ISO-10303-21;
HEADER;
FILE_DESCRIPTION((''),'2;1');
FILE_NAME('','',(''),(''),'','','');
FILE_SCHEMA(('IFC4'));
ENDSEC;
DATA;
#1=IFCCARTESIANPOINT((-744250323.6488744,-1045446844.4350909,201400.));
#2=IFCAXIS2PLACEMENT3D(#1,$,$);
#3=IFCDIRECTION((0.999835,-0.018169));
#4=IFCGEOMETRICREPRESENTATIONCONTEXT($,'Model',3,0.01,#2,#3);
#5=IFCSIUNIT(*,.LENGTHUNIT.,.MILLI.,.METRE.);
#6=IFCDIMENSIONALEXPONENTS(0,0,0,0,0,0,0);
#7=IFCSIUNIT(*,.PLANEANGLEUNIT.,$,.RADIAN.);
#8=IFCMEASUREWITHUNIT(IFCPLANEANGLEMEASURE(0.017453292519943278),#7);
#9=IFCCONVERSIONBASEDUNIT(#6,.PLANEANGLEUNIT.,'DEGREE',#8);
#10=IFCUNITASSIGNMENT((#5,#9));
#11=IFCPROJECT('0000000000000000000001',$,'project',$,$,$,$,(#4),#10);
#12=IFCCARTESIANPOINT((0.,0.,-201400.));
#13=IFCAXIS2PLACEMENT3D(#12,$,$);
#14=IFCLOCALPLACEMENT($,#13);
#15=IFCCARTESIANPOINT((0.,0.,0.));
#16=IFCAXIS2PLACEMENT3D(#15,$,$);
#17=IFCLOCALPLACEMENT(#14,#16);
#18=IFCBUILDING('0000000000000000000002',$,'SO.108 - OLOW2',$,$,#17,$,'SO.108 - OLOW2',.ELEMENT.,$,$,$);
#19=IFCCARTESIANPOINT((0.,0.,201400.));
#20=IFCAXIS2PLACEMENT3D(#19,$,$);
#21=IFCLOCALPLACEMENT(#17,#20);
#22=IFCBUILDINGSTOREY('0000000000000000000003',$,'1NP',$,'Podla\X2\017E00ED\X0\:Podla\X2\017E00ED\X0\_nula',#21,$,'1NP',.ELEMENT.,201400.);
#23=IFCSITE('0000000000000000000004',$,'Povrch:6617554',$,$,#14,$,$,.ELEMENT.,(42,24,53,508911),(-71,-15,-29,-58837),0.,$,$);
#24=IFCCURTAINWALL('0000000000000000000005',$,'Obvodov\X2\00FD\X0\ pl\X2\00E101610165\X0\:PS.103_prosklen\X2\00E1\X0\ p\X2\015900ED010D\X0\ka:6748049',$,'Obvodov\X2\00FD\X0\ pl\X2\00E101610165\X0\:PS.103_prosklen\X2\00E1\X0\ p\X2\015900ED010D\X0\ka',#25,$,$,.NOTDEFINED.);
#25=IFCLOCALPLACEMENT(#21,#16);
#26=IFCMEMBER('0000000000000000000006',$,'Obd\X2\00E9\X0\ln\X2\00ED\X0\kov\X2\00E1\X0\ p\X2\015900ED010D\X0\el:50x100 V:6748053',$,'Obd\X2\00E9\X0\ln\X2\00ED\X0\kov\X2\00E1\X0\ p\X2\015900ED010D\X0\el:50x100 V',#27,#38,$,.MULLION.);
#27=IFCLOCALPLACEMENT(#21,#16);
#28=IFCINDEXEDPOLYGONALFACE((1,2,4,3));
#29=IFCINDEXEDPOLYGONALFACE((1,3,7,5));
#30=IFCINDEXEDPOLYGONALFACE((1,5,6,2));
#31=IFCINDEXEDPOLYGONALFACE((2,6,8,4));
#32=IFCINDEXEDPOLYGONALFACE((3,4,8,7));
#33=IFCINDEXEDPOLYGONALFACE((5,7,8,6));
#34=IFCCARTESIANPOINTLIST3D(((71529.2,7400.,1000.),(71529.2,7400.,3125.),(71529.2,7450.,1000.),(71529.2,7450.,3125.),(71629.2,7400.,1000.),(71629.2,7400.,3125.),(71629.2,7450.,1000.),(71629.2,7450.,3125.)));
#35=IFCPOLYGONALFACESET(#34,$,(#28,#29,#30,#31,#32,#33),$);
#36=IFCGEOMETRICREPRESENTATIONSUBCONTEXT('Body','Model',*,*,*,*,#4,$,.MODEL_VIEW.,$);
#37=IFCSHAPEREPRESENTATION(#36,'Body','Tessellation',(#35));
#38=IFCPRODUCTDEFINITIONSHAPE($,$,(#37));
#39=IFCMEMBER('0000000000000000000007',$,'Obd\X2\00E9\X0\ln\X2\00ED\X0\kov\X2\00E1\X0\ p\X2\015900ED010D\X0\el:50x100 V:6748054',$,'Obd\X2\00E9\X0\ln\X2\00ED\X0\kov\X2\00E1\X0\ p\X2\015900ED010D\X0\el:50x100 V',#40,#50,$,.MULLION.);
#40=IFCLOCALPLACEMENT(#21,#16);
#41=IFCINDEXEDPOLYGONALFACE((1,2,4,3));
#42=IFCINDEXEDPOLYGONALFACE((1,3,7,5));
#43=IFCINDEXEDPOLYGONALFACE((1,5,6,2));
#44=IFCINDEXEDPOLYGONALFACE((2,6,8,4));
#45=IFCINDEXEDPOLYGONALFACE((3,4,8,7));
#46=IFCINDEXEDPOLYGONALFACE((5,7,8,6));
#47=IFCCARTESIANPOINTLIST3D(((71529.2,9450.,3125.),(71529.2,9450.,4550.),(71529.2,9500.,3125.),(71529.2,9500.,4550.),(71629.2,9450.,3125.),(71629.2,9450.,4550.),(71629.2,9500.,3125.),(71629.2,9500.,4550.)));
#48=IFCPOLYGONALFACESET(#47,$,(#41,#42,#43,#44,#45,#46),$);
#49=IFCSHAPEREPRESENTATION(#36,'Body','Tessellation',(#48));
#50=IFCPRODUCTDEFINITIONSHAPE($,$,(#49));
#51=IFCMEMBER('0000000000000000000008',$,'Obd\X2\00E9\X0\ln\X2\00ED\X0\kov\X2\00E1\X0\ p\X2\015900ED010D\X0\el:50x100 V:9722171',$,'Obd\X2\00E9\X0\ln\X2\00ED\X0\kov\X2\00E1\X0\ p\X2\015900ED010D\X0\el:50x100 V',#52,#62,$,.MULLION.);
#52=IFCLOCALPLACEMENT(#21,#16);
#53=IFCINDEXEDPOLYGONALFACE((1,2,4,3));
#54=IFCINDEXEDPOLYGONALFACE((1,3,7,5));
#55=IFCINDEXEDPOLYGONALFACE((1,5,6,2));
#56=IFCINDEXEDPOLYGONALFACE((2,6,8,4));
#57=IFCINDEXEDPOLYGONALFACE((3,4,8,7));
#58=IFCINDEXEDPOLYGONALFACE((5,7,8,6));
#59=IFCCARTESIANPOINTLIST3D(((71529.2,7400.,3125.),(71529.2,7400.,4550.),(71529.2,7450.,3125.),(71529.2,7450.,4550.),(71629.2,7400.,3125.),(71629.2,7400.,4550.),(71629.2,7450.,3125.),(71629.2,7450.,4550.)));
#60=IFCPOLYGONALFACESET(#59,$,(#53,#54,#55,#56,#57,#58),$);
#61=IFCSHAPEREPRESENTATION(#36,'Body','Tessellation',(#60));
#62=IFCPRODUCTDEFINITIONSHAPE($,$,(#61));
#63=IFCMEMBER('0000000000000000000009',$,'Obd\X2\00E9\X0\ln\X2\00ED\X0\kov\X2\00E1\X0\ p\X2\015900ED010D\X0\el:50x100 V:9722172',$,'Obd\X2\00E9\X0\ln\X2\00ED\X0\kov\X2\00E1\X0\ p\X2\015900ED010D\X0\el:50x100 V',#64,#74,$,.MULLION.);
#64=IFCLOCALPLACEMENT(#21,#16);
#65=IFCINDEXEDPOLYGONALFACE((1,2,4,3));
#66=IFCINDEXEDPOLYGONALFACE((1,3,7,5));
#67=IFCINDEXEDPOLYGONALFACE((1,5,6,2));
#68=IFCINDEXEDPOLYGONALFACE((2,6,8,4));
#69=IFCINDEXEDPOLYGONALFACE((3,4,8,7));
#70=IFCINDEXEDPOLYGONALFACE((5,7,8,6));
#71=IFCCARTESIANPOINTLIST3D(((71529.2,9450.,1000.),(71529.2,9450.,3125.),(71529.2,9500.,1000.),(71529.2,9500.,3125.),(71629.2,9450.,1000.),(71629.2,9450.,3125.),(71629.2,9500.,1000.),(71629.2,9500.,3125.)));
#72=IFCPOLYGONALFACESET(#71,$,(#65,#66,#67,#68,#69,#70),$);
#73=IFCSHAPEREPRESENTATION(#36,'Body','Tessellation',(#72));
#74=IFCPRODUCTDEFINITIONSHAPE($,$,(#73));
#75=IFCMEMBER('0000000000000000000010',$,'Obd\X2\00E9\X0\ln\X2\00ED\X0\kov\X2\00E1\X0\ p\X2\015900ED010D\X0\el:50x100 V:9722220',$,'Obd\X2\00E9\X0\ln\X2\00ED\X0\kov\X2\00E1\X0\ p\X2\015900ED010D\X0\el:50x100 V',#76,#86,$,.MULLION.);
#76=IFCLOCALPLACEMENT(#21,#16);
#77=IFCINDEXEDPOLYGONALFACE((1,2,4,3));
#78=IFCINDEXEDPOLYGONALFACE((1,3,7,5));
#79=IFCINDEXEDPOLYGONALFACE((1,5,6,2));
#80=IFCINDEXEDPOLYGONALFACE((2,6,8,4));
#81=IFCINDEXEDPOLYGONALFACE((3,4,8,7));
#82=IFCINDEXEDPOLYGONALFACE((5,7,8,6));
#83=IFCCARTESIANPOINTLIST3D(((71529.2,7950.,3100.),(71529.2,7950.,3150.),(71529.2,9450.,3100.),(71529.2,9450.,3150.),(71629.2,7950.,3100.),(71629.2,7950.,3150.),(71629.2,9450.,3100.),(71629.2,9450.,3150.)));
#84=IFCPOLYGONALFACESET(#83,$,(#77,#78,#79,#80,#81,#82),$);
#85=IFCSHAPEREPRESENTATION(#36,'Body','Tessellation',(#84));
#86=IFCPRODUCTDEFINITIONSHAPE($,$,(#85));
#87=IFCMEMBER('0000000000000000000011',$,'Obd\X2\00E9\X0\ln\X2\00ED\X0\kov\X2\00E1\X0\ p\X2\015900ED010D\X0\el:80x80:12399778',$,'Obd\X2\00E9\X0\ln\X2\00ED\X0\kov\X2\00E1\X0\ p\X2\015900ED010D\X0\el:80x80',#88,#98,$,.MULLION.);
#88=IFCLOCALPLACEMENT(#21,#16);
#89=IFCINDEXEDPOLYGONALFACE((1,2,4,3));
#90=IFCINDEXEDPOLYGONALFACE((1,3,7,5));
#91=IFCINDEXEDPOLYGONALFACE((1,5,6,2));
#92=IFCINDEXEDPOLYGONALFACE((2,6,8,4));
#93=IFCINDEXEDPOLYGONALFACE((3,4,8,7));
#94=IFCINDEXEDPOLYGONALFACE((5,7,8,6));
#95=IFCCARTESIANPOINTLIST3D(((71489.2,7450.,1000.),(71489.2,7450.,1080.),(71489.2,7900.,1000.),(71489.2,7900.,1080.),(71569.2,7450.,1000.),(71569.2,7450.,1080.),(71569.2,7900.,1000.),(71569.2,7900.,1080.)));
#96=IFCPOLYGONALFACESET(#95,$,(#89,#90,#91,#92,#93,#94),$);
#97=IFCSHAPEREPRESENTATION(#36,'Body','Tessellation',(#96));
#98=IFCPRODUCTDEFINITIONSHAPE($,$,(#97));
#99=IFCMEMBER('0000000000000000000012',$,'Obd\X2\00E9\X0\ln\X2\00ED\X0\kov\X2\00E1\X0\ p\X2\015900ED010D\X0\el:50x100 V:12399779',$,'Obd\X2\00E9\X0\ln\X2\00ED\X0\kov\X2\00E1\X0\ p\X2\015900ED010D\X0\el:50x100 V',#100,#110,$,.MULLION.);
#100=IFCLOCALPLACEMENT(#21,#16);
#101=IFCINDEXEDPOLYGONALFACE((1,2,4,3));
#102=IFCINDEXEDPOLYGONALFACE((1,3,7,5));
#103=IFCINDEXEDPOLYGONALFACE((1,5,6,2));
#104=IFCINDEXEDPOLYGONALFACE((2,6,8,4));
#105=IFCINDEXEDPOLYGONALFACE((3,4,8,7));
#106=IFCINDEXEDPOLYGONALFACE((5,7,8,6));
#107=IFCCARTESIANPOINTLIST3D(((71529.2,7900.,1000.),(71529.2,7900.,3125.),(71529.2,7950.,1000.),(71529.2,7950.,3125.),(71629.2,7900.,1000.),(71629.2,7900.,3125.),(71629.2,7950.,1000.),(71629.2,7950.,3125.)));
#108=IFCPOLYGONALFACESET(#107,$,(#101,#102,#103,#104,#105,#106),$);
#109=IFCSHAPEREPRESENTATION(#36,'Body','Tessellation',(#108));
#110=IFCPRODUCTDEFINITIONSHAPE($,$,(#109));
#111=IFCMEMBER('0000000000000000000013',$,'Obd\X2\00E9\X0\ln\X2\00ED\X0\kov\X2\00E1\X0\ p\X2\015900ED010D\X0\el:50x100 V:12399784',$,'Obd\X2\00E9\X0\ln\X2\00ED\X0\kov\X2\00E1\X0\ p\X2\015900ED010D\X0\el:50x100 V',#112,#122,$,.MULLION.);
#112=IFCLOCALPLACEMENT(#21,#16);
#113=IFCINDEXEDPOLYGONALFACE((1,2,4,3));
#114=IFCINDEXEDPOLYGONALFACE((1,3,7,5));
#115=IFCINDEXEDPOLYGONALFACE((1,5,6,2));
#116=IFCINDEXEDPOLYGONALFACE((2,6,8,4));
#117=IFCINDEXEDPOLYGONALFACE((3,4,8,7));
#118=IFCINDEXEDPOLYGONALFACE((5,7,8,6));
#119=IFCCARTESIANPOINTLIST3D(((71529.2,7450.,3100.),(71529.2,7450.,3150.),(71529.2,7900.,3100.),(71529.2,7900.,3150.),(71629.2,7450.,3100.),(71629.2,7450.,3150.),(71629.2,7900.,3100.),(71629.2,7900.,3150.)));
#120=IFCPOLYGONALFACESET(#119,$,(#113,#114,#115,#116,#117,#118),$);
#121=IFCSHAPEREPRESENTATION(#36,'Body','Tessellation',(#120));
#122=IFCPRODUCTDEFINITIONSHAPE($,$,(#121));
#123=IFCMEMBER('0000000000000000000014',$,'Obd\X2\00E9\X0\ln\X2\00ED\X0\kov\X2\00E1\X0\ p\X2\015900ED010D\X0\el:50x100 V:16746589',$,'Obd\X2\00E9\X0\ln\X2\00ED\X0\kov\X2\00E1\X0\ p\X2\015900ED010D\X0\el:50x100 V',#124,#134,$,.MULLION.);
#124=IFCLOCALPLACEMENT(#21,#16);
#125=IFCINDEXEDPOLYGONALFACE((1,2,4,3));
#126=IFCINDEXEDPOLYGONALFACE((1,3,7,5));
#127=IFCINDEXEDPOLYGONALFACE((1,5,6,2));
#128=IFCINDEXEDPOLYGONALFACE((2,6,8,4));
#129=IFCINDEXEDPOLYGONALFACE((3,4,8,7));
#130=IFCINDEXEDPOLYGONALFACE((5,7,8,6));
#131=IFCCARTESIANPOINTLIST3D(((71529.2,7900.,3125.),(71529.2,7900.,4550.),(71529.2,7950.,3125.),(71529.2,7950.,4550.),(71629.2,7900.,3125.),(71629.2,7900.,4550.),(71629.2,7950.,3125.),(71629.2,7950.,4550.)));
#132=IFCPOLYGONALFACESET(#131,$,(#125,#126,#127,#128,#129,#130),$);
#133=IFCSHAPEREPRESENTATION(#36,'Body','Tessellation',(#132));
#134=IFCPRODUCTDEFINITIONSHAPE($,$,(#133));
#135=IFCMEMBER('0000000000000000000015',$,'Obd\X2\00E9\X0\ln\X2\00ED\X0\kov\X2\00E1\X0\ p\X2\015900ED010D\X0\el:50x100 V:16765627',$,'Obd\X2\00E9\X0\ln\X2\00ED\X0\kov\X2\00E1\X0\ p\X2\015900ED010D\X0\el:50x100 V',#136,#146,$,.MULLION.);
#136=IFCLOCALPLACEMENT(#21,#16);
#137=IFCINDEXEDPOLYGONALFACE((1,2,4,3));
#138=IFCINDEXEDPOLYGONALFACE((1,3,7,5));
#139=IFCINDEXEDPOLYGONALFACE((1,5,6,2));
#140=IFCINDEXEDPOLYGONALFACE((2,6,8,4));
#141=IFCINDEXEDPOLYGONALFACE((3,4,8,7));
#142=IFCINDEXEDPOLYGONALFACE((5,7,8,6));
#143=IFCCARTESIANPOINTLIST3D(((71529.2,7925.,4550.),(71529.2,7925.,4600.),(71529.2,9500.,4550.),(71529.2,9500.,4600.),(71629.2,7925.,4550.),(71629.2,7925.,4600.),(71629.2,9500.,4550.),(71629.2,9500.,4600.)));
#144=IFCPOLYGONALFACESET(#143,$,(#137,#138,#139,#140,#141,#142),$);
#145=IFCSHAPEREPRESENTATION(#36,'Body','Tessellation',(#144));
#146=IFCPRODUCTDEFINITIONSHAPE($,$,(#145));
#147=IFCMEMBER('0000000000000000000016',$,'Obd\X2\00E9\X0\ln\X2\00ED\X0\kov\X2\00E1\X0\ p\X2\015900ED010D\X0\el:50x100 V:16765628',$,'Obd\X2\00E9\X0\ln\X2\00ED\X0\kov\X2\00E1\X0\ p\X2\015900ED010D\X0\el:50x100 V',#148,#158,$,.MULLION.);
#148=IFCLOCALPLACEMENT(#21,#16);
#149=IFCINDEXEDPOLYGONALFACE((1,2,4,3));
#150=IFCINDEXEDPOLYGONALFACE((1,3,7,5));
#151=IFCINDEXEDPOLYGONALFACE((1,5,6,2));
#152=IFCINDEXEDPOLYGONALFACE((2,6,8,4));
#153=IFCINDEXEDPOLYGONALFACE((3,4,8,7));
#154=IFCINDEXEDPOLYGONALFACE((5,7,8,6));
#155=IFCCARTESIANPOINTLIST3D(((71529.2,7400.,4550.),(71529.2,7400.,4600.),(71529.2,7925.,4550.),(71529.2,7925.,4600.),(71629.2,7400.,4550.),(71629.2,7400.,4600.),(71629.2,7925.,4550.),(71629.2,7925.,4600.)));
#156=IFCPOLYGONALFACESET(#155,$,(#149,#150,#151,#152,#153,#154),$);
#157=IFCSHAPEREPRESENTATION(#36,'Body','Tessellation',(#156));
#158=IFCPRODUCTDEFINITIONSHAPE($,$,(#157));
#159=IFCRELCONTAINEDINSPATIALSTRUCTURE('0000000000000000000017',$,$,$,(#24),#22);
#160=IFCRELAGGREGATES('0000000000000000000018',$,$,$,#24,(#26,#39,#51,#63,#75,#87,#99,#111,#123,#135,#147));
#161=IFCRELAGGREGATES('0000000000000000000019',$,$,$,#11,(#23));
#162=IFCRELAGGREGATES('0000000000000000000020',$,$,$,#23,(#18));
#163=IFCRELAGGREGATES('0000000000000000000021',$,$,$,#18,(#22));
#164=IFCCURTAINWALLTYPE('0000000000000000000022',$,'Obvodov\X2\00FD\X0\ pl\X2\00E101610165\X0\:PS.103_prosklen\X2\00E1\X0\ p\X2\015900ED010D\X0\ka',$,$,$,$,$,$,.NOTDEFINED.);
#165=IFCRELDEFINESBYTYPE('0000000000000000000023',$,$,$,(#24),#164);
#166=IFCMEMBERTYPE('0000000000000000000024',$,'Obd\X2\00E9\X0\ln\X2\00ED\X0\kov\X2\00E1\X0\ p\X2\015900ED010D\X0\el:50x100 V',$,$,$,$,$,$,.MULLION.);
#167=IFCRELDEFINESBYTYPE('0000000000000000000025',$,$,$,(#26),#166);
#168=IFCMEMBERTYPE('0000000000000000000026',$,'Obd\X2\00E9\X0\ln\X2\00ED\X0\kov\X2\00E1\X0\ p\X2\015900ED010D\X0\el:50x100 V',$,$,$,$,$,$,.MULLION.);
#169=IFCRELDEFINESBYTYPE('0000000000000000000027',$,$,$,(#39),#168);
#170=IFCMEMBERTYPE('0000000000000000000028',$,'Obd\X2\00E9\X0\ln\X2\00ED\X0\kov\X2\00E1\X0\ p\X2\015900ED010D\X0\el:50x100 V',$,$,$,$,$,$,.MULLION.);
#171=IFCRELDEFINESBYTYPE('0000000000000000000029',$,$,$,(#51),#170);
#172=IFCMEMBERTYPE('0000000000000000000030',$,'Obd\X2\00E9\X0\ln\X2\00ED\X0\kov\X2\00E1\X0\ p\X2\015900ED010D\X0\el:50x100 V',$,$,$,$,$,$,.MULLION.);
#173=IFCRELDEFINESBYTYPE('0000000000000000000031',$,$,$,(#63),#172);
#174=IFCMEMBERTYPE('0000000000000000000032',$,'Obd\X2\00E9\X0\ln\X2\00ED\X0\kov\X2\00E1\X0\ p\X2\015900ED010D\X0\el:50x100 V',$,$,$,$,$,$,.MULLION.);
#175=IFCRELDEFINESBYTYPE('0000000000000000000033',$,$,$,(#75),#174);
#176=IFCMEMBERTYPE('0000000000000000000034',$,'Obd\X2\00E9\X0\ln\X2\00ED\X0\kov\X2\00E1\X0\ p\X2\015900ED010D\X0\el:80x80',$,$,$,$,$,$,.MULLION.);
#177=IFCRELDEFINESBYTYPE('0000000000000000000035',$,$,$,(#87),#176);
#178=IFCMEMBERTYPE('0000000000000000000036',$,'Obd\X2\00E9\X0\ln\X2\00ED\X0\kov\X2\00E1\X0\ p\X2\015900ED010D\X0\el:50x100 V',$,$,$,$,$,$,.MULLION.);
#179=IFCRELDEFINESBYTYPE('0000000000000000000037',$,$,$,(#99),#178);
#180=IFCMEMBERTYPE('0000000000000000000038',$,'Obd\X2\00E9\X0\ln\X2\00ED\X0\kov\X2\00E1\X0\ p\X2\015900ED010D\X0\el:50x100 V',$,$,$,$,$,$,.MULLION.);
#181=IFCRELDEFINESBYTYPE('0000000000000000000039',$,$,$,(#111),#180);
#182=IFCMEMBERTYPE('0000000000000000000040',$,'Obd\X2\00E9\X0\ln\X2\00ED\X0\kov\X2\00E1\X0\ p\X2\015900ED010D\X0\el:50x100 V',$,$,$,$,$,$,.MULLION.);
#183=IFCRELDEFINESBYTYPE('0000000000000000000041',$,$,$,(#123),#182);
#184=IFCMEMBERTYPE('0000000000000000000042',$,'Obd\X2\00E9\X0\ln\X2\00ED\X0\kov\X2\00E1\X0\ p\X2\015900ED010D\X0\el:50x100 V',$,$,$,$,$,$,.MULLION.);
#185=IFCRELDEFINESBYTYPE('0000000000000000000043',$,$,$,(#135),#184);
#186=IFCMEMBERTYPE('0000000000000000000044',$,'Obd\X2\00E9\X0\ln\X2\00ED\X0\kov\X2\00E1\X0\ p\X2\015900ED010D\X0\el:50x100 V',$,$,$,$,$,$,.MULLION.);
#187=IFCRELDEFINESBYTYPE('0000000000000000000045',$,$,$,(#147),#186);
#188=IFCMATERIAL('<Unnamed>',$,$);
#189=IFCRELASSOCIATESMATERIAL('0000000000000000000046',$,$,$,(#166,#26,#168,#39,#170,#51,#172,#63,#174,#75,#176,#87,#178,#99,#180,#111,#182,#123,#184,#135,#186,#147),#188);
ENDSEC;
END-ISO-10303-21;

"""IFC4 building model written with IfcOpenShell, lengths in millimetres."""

from ifc_helpers import new_model, entity, si_unit, converted_unit, direction, frame, origin, place, context, subcontext, project, spatial, indexed_curve, outline, extrude, source, transform, mapped, material, type_object, type_shapes, element, aggregate, save


model = new_model("IFC4")

# Units and contexts
model_context = context("Model", 3, precision=0.01, world=frame((-744250323.6488744, -1045446844.4350909, 201400.0)), true_north=direction((0.999835, -0.018169)))
body_context = subcontext(model_context, "Body", "Model", "MODEL_VIEW")
ifc_project = project(units=[si_unit("LENGTHUNIT", "METRE", prefix="MILLI"), converted_unit("PLANEANGLEUNIT", "DEGREE", entity("IfcPlaneAngleMeasure", 0.017453292519943278), si_unit("PLANEANGLEUNIT", "RADIAN"), dimensions=[0, 0, 0, 0, 0, 0, 0])], contexts=[model_context])

# Site, building, storey
site_placement = place(None, frame((0.0, 0.0, -201400.0)))
site = spatial("IfcSite", under=ifc_project, at=site_placement, Name="Povrch:6617554", CompositionType="ELEMENT", RefLatitude=(42, 24, 53, 508911), RefLongitude=(-71, -15, -29, -58837), RefElevation=0.0)
building_placement = place(site_placement, origin())
building = spatial("IfcBuilding", under=site, at=building_placement, Name="SO.108 - OLOW2", LongName="SO.108 - OLOW2", CompositionType="ELEMENT")
storey_placement = place(building_placement, frame((0.0, 0.0, 201400.0)))
storey = spatial("IfcBuildingStorey", under=building, at=storey_placement, Name="1NP", ObjectType="Podlaží:Podlaží_nula", LongName="1NP", CompositionType="ELEMENT", Elevation=201400.0)

# Curtain wall, members
curtain_wall_type_1 = type_object("IfcCurtainWallType", Name="Obvodový plášť:PS.103_prosklená příčka", PredefinedType="NOTDEFINED")
curtain_wall_1_placement = place(storey_placement, frame((0.0, 0.0, -201400.0)))
curtain_wall_1 = element("IfcCurtainWall", 1, at=curtain_wall_1_placement, inside=storey, type_object=curtain_wall_type_1, Name="Obvodový plášť:PS.103_prosklená příčka:6748049", ObjectType="Obvodový plášť:PS.103_prosklená příčka", PredefinedType="NOTDEFINED")
ifc_material_1 = material(Name="<Unnamed>")
member_type_1 = type_object("IfcMemberType", Name="Obdélníková příčel:50x100 V", PredefinedType="MULLION", material=ifc_material_1)
shared_shape_1 = source(origin(), body_context, "Body", "SweptSolid", [
    extrude(outline(indexed_curve([(-25.0, -50.0), (25.0, -50.0), (25.0, 50.0), (-25.0, 50.0), (-25.0, -50.0)], self_intersect=False)), frame((-25.0, -50.0, -2125.0), z_axis=(0.0, 0.0, 1.0), x_axis=(-1.0, 0.0, 0.0)), (0.0, 0.0, 1.0), 2125.0),
])
type_shapes(member_type_1, [shared_shape_1])
member_1_placement = place(curtain_wall_1_placement, frame((71529.2, 7400.0, 202400.0), z_axis=(0.0, 0.0, -1.0), x_axis=(0.0, -1.0, 0.0)))
member_1 = element("IfcMember", 2, at=member_1_placement, type_object=member_type_1, material=ifc_material_1, Name="Obdélníková příčel:50x100 V:6748053", ObjectType="Obdélníková příčel:50x100 V", PredefinedType="MULLION", context=body_context, shape_type="MappedRepresentation", body=[
    mapped(shared_shape_1, transform((0.0, 0.0, 0.0), scale=1.0)),
])
member_type_2 = type_object("IfcMemberType", Name="Obdélníková příčel:50x100 V", PredefinedType="MULLION", material=ifc_material_1)
shared_shape_2 = source(origin(), body_context, "Body", "SweptSolid", [
    extrude(outline(indexed_curve([(-25.0, -50.0), (25.0, -50.0), (25.0, 50.0), (-25.0, 50.0), (-25.0, -50.0)], self_intersect=False)), frame((-25.0, -50.0, -1425.0), z_axis=(0.0, 0.0, 1.0), x_axis=(-1.0, 0.0, 0.0)), (0.0, 0.0, 1.0), 1425.0),
])
type_shapes(member_type_2, [shared_shape_2])
member_2_placement = place(curtain_wall_1_placement, frame((71529.2, 9500.0, 205950.0), z_axis=(0.0, 0.0, 1.0), x_axis=(0.0, 1.0, 0.0)))
member_2 = element("IfcMember", 3, at=member_2_placement, type_object=member_type_2, material=ifc_material_1, Name="Obdélníková příčel:50x100 V:6748054", ObjectType="Obdélníková příčel:50x100 V", PredefinedType="MULLION", context=body_context, shape_type="MappedRepresentation", body=[
    mapped(shared_shape_2, transform((0.0, 0.0, 0.0), scale=1.0)),
])
member_type_3 = type_object("IfcMemberType", Name="Obdélníková příčel:50x100 V", PredefinedType="MULLION", material=ifc_material_1)
shared_shape_3 = source(origin(), body_context, "Body", "SweptSolid", [
    extrude(outline(indexed_curve([(-25.0, -50.0), (25.0, -50.0), (25.0, 50.0), (-25.0, 50.0), (-25.0, -50.0)], self_intersect=False)), frame((-25.0, -50.0, -1425.0), z_axis=(0.0, 0.0, 1.0), x_axis=(-1.0, 0.0, 0.0)), (0.0, 0.0, 1.0), 1425.0),
])
type_shapes(member_type_3, [shared_shape_3])
member_3_placement = place(curtain_wall_1_placement, frame((71529.2, 7400.0, 204525.0), z_axis=(0.0, 0.0, -1.0), x_axis=(0.0, -1.0, 0.0)))
member_3 = element("IfcMember", 4, at=member_3_placement, type_object=member_type_3, material=ifc_material_1, Name="Obdélníková příčel:50x100 V:9722171", ObjectType="Obdélníková příčel:50x100 V", PredefinedType="MULLION", context=body_context, shape_type="MappedRepresentation", body=[
    mapped(shared_shape_3, transform((0.0, 0.0, 0.0), scale=1.0)),
])
member_type_4 = type_object("IfcMemberType", Name="Obdélníková příčel:50x100 V", PredefinedType="MULLION", material=ifc_material_1)
shared_shape_4 = source(origin(), body_context, "Body", "SweptSolid", [
    extrude(outline(indexed_curve([(-25.0, -50.0), (25.0, -50.0), (25.0, 50.0), (-25.0, 50.0), (-25.0, -50.0)], self_intersect=False)), frame((-25.0, -50.0, -2125.0), z_axis=(0.0, 0.0, 1.0), x_axis=(-1.0, 0.0, 0.0)), (0.0, 0.0, 1.0), 2125.0),
])
type_shapes(member_type_4, [shared_shape_4])
member_4_placement = place(curtain_wall_1_placement, frame((71529.2, 9500.0, 204525.0), z_axis=(0.0, 0.0, 1.0), x_axis=(0.0, 1.0, 0.0)))
member_4 = element("IfcMember", 5, at=member_4_placement, type_object=member_type_4, material=ifc_material_1, Name="Obdélníková příčel:50x100 V:9722172", ObjectType="Obdélníková příčel:50x100 V", PredefinedType="MULLION", context=body_context, shape_type="MappedRepresentation", body=[
    mapped(shared_shape_4, transform((0.0, 0.0, 0.0), scale=1.0)),
])
member_type_5 = type_object("IfcMemberType", Name="Obdélníková příčel:50x100 V", PredefinedType="MULLION", material=ifc_material_1)
shared_shape_5 = source(origin(), body_context, "Body", "SweptSolid", [
    extrude(outline(indexed_curve([(-25.0, -50.0), (25.0, -50.0), (25.0, 50.0), (-25.0, 50.0), (-25.0, -50.0)], self_intersect=False)), frame((0.0, -50.0, -1500.0), z_axis=(0.0, 0.0, 1.0), x_axis=(-1.0, 0.0, 0.0)), (0.0, 0.0, 1.0), 1500.0),
])
type_shapes(member_type_5, [shared_shape_5])
member_5_placement = place(curtain_wall_1_placement, frame((71529.2, 7950.0, 204525.0), z_axis=(0.0, -1.0, 0.0), x_axis=(0.0, 0.0, 1.0)))
member_5 = element("IfcMember", 6, at=member_5_placement, type_object=member_type_5, material=ifc_material_1, Name="Obdélníková příčel:50x100 V:9722220", ObjectType="Obdélníková příčel:50x100 V", PredefinedType="MULLION", context=body_context, shape_type="MappedRepresentation", body=[
    mapped(shared_shape_5, transform((0.0, 0.0, 0.0), scale=1.0)),
])
member_type_6 = type_object("IfcMemberType", Name="Obdélníková příčel:80x80", PredefinedType="MULLION", material=ifc_material_1)
shared_shape_6 = source(origin(), body_context, "Body", "SweptSolid", [
    extrude(outline(indexed_curve([(-40.0, -40.0), (40.0, -40.0), (40.0, 40.0), (-40.0, 40.0), (-40.0, -40.0)], self_intersect=False)), frame((-40.0, 0.0, -450.0), z_axis=(0.0, 0.0, 1.0), x_axis=(-1.0, 0.0, 0.0)), (0.0, 0.0, 1.0), 450.0),
])
type_shapes(member_type_6, [shared_shape_6])
member_6_placement = place(curtain_wall_1_placement, frame((71529.2, 7900.0, 202400.0), z_axis=(0.0, 1.0, 0.0), x_axis=(0.0, 0.0, -1.0)))
member_6 = element("IfcMember", 7, at=member_6_placement, type_object=member_type_6, material=ifc_material_1, Name="Obdélníková příčel:80x80:12399778", ObjectType="Obdélníková příčel:80x80", PredefinedType="MULLION", context=body_context, shape_type="MappedRepresentation", body=[
    mapped(shared_shape_6, transform((0.0, 0.0, 0.0), scale=1.0)),
])
member_type_7 = type_object("IfcMemberType", Name="Obdélníková příčel:50x100 V", PredefinedType="MULLION", material=ifc_material_1)
shared_shape_7 = source(origin(), body_context, "Body", "SweptSolid", [
    extrude(outline(indexed_curve([(-25.0, -50.0), (25.0, -50.0), (25.0, 50.0), (-25.0, 50.0), (-25.0, -50.0)], self_intersect=False)), frame((0.0, -50.0, -2125.0), z_axis=(0.0, 0.0, 1.0), x_axis=(-1.0, 0.0, 0.0)), (0.0, 0.0, 1.0), 2125.0),
])
type_shapes(member_type_7, [shared_shape_7])
member_7_placement = place(curtain_wall_1_placement, frame((71529.2, 7925.0, 202400.0), z_axis=(0.0, 0.0, -1.0), x_axis=(0.0, -1.0, 0.0)))
member_7 = element("IfcMember", 8, at=member_7_placement, type_object=member_type_7, material=ifc_material_1, Name="Obdélníková příčel:50x100 V:12399779", ObjectType="Obdélníková příčel:50x100 V", PredefinedType="MULLION", context=body_context, shape_type="MappedRepresentation", body=[
    mapped(shared_shape_7, transform((0.0, 0.0, 0.0), scale=1.0)),
])
member_type_8 = type_object("IfcMemberType", Name="Obdélníková příčel:50x100 V", PredefinedType="MULLION", material=ifc_material_1)
shared_shape_8 = source(origin(), body_context, "Body", "SweptSolid", [
    extrude(outline(indexed_curve([(-25.0, -50.0), (25.0, -50.0), (25.0, 50.0), (-25.0, 50.0), (-25.0, -50.0)], self_intersect=False)), frame((0.0, -50.0, -450.0), z_axis=(0.0, 0.0, 1.0), x_axis=(-1.0, 0.0, 0.0)), (0.0, 0.0, 1.0), 450.0),
])
type_shapes(member_type_8, [shared_shape_8])
member_8_placement = place(curtain_wall_1_placement, frame((71529.2, 7450.0, 204525.0), z_axis=(0.0, -1.0, 0.0), x_axis=(0.0, 0.0, 1.0)))
member_8 = element("IfcMember", 9, at=member_8_placement, type_object=member_type_8, material=ifc_material_1, Name="Obdélníková příčel:50x100 V:12399784", ObjectType="Obdélníková příčel:50x100 V", PredefinedType="MULLION", context=body_context, shape_type="MappedRepresentation", body=[
    mapped(shared_shape_8, transform((0.0, 0.0, 0.0), scale=1.0)),
])
member_type_9 = type_object("IfcMemberType", Name="Obdélníková příčel:50x100 V", PredefinedType="MULLION", material=ifc_material_1)
shared_shape_9 = source(origin(), body_context, "Body", "SweptSolid", [
    extrude(outline(indexed_curve([(-25.0, -50.0), (25.0, -50.0), (25.0, 50.0), (-25.0, 50.0), (-25.0, -50.0)], self_intersect=False)), frame((0.0, -50.0, -1425.0), z_axis=(0.0, 0.0, 1.0), x_axis=(-1.0, 0.0, 0.0)), (0.0, 0.0, 1.0), 1425.0),
])
type_shapes(member_type_9, [shared_shape_9])
member_9_placement = place(curtain_wall_1_placement, frame((71529.2, 7925.0, 204525.0), z_axis=(0.0, 0.0, -1.0), x_axis=(0.0, -1.0, 0.0)))
member_9 = element("IfcMember", 10, at=member_9_placement, type_object=member_type_9, material=ifc_material_1, Name="Obdélníková příčel:50x100 V:16746589", ObjectType="Obdélníková příčel:50x100 V", PredefinedType="MULLION", context=body_context, shape_type="MappedRepresentation", body=[
    mapped(shared_shape_9, transform((0.0, 0.0, 0.0), scale=1.0)),
])
member_type_10 = type_object("IfcMemberType", Name="Obdélníková příčel:50x100 V", PredefinedType="MULLION", material=ifc_material_1)
shared_shape_10 = source(origin(), body_context, "Body", "SweptSolid", [
    extrude(outline(indexed_curve([(-25.0, -50.0), (25.0, -50.0), (25.0, 50.0), (-25.0, 50.0), (-25.0, -50.0)], self_intersect=False)), frame((-25.0, -50.0, -1575.0), z_axis=(0.0, 0.0, 1.0), x_axis=(-1.0, 0.0, 0.0)), (0.0, 0.0, 1.0), 1575.0),
])
type_shapes(member_type_10, [shared_shape_10])
member_10_placement = place(curtain_wall_1_placement, frame((71529.2, 7925.0, 206000.0), z_axis=(0.0, -1.0, 0.0), x_axis=(0.0, 0.0, 1.0)))
member_10 = element("IfcMember", 11, at=member_10_placement, type_object=member_type_10, material=ifc_material_1, Name="Obdélníková příčel:50x100 V:16765627", ObjectType="Obdélníková příčel:50x100 V", PredefinedType="MULLION", context=body_context, shape_type="MappedRepresentation", body=[
    mapped(shared_shape_10, transform((0.0, 0.0, 0.0), scale=1.0)),
])
member_type_11 = type_object("IfcMemberType", Name="Obdélníková příčel:50x100 V", PredefinedType="MULLION", material=ifc_material_1)
shared_shape_11 = source(origin(), body_context, "Body", "SweptSolid", [
    extrude(outline(indexed_curve([(-25.0, -50.0), (25.0, -50.0), (25.0, 50.0), (-25.0, 50.0), (-25.0, -50.0)], self_intersect=False)), frame((-25.0, -50.0, -525.0), z_axis=(0.0, 0.0, 1.0), x_axis=(-1.0, 0.0, 0.0)), (0.0, 0.0, 1.0), 525.0),
])
type_shapes(member_type_11, [shared_shape_11])
member_11_placement = place(curtain_wall_1_placement, frame((71529.2, 7400.0, 206000.0), z_axis=(0.0, -1.0, 0.0), x_axis=(0.0, 0.0, 1.0)))
member_11 = element("IfcMember", 12, at=member_11_placement, type_object=member_type_11, material=ifc_material_1, Name="Obdélníková příčel:50x100 V:16765628", ObjectType="Obdélníková příčel:50x100 V", PredefinedType="MULLION", context=body_context, shape_type="MappedRepresentation", body=[
    mapped(shared_shape_11, transform((0.0, 0.0, 0.0), scale=1.0)),
])

aggregate(curtain_wall_1, [member_1, member_2, member_3, member_4, member_5, member_6, member_7, member_8, member_9, member_10, member_11])

save(model, "model.ifc")
